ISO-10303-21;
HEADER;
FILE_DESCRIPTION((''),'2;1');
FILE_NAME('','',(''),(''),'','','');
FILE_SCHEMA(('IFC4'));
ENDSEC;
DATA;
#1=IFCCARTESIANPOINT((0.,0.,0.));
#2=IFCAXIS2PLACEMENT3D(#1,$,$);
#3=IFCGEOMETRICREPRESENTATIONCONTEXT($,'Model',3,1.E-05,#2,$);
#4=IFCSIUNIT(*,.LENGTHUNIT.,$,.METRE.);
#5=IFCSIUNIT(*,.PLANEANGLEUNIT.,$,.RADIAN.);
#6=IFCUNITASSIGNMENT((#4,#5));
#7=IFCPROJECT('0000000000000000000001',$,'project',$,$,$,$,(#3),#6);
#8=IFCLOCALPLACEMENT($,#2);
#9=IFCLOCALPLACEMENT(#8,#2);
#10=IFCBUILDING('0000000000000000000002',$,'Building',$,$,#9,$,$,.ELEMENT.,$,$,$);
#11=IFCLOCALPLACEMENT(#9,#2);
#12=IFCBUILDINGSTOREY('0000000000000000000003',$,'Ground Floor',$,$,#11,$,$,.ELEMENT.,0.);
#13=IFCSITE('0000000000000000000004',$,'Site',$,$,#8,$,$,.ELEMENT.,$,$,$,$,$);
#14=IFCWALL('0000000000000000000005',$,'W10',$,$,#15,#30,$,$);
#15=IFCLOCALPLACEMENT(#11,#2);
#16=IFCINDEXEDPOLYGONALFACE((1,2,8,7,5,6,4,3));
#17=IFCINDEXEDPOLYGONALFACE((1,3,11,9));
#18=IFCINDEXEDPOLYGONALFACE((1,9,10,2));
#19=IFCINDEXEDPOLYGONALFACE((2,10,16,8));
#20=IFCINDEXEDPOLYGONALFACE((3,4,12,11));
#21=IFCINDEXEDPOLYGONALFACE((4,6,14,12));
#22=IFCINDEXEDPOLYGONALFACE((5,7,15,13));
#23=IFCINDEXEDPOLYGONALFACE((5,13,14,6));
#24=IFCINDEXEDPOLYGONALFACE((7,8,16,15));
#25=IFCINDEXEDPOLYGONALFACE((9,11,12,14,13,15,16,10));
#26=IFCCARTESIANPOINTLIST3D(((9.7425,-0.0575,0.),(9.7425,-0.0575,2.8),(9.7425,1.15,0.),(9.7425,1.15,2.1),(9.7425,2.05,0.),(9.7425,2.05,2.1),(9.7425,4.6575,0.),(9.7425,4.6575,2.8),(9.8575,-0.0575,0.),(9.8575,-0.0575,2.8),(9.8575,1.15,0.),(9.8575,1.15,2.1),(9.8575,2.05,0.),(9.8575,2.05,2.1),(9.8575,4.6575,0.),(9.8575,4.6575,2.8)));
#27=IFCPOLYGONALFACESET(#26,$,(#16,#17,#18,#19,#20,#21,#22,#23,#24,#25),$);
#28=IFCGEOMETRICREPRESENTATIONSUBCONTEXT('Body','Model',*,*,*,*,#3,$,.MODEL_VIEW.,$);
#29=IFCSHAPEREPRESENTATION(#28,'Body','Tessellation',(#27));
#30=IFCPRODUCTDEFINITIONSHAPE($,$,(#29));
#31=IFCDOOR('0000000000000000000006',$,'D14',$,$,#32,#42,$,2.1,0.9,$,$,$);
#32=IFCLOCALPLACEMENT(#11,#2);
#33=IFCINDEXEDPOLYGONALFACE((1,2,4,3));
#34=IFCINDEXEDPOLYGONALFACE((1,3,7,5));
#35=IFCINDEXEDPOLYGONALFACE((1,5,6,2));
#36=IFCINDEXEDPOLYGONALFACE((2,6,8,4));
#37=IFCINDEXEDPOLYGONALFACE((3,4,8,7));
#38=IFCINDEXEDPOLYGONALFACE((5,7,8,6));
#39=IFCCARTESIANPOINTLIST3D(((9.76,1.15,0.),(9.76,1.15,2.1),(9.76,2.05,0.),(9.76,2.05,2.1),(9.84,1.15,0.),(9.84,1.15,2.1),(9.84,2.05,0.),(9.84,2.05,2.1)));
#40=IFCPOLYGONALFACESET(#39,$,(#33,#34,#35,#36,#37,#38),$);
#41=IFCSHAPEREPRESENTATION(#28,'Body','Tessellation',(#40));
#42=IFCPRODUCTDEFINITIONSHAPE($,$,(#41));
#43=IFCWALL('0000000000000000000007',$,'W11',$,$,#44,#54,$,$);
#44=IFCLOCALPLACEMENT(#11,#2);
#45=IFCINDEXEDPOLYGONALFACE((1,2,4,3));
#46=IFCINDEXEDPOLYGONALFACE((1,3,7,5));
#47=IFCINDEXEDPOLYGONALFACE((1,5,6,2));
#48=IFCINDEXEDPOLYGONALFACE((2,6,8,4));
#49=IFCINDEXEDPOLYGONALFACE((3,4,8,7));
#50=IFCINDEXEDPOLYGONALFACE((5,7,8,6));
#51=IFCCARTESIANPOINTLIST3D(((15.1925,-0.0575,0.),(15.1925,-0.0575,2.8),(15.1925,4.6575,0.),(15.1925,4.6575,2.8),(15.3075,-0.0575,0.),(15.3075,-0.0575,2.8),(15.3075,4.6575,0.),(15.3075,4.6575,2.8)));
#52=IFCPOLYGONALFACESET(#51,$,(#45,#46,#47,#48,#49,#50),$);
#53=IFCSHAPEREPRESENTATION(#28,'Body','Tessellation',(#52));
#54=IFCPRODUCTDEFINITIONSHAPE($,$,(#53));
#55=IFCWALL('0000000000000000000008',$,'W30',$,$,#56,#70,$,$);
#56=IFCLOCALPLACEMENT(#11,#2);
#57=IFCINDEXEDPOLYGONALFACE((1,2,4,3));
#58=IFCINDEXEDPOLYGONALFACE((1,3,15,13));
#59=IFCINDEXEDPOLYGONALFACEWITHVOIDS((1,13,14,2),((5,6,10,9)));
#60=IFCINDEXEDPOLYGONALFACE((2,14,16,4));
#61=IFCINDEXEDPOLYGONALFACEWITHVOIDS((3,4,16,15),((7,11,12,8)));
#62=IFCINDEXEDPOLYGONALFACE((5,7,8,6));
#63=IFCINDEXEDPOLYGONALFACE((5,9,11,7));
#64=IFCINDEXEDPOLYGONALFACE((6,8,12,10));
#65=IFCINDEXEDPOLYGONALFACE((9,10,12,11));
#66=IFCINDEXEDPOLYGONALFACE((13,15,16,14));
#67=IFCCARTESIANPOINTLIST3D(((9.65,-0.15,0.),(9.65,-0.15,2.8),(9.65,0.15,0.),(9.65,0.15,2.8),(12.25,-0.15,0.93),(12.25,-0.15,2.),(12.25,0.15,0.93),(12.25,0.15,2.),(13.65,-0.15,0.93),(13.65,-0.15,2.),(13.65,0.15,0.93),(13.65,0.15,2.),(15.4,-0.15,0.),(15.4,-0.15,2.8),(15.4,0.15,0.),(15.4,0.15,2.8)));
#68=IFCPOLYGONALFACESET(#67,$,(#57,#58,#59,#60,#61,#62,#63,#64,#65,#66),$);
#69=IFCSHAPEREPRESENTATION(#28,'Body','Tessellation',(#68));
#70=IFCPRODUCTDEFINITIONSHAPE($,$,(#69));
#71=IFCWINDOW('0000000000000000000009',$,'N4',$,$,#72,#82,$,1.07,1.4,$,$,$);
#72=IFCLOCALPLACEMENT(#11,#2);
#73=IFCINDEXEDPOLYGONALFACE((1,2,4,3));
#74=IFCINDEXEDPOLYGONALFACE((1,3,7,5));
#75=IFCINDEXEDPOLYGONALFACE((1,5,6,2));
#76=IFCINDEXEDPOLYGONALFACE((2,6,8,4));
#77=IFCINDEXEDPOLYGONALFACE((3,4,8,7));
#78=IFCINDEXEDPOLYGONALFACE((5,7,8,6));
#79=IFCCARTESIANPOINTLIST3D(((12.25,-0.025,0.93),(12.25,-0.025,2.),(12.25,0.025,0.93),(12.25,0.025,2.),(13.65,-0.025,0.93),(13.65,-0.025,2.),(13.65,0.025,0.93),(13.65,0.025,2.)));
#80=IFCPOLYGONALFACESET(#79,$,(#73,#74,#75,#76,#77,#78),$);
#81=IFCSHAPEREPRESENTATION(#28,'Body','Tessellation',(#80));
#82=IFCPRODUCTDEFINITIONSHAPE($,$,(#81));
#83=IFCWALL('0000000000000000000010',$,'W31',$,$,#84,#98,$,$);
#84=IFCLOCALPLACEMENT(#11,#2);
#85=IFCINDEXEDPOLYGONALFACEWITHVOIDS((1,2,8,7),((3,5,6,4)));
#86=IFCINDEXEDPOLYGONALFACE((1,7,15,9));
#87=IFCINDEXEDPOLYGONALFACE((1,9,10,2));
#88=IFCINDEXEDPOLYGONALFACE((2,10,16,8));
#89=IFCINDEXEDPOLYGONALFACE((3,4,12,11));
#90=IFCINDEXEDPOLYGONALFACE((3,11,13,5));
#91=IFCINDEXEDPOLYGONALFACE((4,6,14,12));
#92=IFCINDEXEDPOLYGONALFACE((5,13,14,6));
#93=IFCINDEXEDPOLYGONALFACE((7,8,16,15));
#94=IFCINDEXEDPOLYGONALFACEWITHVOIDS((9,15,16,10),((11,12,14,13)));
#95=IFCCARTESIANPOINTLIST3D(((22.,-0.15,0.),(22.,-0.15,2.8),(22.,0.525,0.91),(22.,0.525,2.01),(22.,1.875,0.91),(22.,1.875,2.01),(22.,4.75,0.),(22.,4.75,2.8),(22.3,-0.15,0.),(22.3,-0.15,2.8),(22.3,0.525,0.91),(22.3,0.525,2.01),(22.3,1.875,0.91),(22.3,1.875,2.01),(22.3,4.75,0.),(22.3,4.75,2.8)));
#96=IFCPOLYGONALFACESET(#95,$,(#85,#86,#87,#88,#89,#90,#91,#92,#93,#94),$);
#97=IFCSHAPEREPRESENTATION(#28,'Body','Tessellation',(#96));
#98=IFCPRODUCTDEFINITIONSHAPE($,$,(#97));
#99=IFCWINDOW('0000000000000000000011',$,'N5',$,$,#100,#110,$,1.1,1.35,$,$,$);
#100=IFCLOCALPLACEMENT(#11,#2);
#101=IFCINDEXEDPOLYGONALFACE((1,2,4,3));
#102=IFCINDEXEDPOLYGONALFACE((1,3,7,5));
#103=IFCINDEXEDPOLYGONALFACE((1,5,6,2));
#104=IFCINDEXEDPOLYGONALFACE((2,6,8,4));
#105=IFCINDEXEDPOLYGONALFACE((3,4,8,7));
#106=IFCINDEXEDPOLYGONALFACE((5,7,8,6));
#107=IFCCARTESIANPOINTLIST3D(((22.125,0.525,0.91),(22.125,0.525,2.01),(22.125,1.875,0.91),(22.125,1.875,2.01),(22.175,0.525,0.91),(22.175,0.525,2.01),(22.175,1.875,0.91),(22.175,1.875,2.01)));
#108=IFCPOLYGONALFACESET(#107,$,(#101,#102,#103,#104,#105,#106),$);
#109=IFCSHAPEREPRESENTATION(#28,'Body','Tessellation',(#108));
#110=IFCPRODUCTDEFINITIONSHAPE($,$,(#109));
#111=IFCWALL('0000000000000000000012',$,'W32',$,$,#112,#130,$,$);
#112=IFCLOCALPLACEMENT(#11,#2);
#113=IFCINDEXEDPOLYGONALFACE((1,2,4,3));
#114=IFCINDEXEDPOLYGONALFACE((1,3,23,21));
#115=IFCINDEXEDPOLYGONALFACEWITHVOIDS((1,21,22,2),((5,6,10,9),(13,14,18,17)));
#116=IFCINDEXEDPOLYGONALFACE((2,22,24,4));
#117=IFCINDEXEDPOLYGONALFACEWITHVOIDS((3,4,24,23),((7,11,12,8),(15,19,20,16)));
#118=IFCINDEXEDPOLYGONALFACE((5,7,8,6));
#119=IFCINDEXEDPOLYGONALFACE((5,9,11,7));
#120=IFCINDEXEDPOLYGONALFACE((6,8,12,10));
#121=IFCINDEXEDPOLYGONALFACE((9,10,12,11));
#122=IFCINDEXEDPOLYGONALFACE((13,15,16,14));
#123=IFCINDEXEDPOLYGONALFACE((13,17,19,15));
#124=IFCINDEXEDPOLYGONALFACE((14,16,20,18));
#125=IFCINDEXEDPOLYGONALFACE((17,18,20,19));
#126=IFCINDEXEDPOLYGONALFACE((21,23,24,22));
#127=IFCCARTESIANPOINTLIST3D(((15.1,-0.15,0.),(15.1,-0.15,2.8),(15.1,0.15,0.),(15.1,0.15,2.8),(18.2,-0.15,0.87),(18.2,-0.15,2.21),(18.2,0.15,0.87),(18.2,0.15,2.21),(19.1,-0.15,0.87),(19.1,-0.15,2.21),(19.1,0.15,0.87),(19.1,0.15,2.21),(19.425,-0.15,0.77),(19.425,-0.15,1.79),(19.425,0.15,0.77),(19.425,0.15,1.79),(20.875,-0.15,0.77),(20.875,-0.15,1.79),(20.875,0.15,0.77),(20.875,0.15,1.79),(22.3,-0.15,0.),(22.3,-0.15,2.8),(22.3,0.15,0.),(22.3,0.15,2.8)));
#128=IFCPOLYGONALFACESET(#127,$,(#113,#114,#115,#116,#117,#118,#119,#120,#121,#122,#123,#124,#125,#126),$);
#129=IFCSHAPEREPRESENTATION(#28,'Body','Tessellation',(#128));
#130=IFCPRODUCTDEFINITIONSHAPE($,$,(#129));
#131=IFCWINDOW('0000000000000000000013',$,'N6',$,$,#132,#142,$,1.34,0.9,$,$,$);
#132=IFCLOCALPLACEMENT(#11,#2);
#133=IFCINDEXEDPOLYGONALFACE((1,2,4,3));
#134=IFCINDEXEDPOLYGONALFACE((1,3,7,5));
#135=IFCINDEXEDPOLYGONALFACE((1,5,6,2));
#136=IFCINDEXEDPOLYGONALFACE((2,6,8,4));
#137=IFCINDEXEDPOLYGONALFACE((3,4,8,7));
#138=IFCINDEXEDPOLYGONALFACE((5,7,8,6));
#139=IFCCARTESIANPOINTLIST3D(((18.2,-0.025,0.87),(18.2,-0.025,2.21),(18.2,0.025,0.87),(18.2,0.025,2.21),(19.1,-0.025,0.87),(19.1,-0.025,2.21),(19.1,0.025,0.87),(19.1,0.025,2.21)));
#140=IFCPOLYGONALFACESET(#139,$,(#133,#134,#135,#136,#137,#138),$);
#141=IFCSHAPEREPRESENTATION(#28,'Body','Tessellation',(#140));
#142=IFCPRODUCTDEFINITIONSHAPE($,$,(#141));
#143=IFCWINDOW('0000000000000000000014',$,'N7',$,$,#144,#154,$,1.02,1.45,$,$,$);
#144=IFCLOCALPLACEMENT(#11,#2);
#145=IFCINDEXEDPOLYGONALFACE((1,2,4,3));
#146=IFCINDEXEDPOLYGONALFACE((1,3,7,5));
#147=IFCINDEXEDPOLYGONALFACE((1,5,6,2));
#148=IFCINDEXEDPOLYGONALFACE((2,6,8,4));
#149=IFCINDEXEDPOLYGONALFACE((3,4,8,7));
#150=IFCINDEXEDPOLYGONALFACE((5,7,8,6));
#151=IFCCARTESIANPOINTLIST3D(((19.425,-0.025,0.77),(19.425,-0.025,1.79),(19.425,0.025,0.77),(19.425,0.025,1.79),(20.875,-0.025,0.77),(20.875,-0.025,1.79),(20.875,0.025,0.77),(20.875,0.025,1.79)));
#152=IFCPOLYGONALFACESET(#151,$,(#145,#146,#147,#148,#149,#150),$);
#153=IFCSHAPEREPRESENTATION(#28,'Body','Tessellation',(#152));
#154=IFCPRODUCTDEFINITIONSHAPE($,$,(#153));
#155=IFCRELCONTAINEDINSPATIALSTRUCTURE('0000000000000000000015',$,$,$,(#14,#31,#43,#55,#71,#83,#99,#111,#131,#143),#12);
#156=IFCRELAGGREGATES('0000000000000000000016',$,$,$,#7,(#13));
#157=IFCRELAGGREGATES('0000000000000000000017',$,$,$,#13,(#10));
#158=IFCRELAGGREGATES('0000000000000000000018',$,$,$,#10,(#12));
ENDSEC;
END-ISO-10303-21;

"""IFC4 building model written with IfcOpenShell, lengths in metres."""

from ifc_helpers import new_model, si_unit, frame, frame_2d, origin, origin_2d, place, context, subcontext, project, spatial, rectangle, extrude, element, fill, save


model = new_model("IFC4")

# Units and contexts
model_context = context("Model", 3, precision=1e-05, world=origin())
body_context = subcontext(model_context, "Body", "Model", "MODEL_VIEW")
ifc_project = project(units=[si_unit("LENGTHUNIT", "METRE"), si_unit("PLANEANGLEUNIT", "RADIAN")], contexts=[model_context])

# Site, building, storey
site_placement = place(None, origin())
site = spatial("IfcSite", under=ifc_project, at=site_placement, Name="Site", CompositionType="ELEMENT")
building_placement = place(site_placement, origin())
building = spatial("IfcBuilding", under=site, at=building_placement, Name="Building", CompositionType="ELEMENT")
storey_placement = place(building_placement, origin())
storey = spatial("IfcBuildingStorey", under=building, at=storey_placement, Name="Ground Floor", CompositionType="ELEMENT", Elevation=0.0)

# Wall, opening, door
wall_1_placement = place(storey_placement, frame((9.8, 0.0, 0.0), x_axis=(0.0, 1.0, 0.0)))
wall_1 = element("IfcWall", 1, at=wall_1_placement, inside=storey, Name="W10", context=body_context, shape_type="SweptSolid", body=[
    extrude(rectangle(XDim=4.715, YDim=0.115, at=frame_2d((2.3, 0.0))), origin(), (0.0, 0.0, 1.0), 2.8),
])
opening_1_placement = place(wall_1_placement, frame((1.6, 0.0, 0.0)))
opening_1 = element("IfcOpeningElement", 2, at=opening_1_placement, cuts=wall_1, context=body_context, shape_type="SweptSolid", body=[
    extrude(rectangle(XDim=0.9, YDim=0.215, at=origin_2d()), origin(), (0.0, 0.0, 1.0), 2.1),
])
door_1_placement = place(opening_1_placement, origin())
door_1 = element("IfcDoor", 3, at=door_1_placement, inside=storey, Name="D14", OverallHeight=2.1, OverallWidth=0.9, context=body_context, shape_type="SweptSolid", body=[
    extrude(rectangle(XDim=0.9, YDim=0.08, at=origin_2d()), origin(), (0.0, 0.0, 1.0), 2.1),
])
fill(opening_1, door_1)

# Wall
wall_2_placement = place(storey_placement, frame((15.25, 0.0, 0.0), x_axis=(0.0, 1.0, 0.0)))
element("IfcWall", 4, at=wall_2_placement, inside=storey, Name="W11", context=body_context, shape_type="SweptSolid", body=[
    extrude(rectangle(XDim=4.715, YDim=0.115, at=frame_2d((2.3, 0.0))), origin(), (0.0, 0.0, 1.0), 2.8),
])

# Walls, openings, windows
wall_3_placement = place(storey_placement, frame((9.8, 0.0, 0.0), x_axis=(1.0, 0.0, 0.0)))
wall_3 = element("IfcWall", 5, at=wall_3_placement, inside=storey, Name="W30", context=body_context, shape_type="SweptSolid", body=[
    extrude(rectangle(XDim=5.75, YDim=0.3, at=frame_2d((2.725, 0.0))), origin(), (0.0, 0.0, 1.0), 2.8),
])
opening_2_placement = place(wall_3_placement, frame((3.15, 0.0, 0.93)))
opening_2 = element("IfcOpeningElement", 6, at=opening_2_placement, cuts=wall_3, context=body_context, shape_type="SweptSolid", body=[
    extrude(rectangle(XDim=1.4, YDim=0.4, at=origin_2d()), origin(), (0.0, 0.0, 1.0), 1.07),
])
window_1_placement = place(opening_2_placement, origin())
window_1 = element("IfcWindow", 7, at=window_1_placement, inside=storey, Name="N4", OverallHeight=1.07, OverallWidth=1.4, context=body_context, shape_type="SweptSolid", body=[
    extrude(rectangle(XDim=1.4, YDim=0.05, at=origin_2d()), origin(), (0.0, 0.0, 1.0), 1.07),
])
fill(opening_2, window_1)
wall_4_placement = place(storey_placement, frame((22.15, 0.0, 0.0), x_axis=(0.0, 1.0, 0.0)))
wall_4 = element("IfcWall", 8, at=wall_4_placement, inside=storey, Name="W31", context=body_context, shape_type="SweptSolid", body=[
    extrude(rectangle(XDim=4.9, YDim=0.3, at=frame_2d((2.3, 0.0))), origin(), (0.0, 0.0, 1.0), 2.8),
])
opening_3_placement = place(wall_4_placement, frame((1.2, 0.0, 0.91)))
opening_3 = element("IfcOpeningElement", 9, at=opening_3_placement, cuts=wall_4, context=body_context, shape_type="SweptSolid", body=[
    extrude(rectangle(XDim=1.35, YDim=0.4, at=origin_2d()), origin(), (0.0, 0.0, 1.0), 1.1),
])
window_2_placement = place(opening_3_placement, origin())
window_2 = element("IfcWindow", 10, at=window_2_placement, inside=storey, Name="N5", OverallHeight=1.1, OverallWidth=1.35, context=body_context, shape_type="SweptSolid", body=[
    extrude(rectangle(XDim=1.35, YDim=0.05, at=origin_2d()), origin(), (0.0, 0.0, 1.0), 1.1),
])
fill(opening_3, window_2)

# Wall, openings, windows
wall_5_placement = place(storey_placement, frame((15.25, 0.0, 0.0), x_axis=(1.0, 0.0, 0.0)))
wall_5 = element("IfcWall", 11, at=wall_5_placement, inside=storey, Name="W32", context=body_context, shape_type="SweptSolid", body=[
    extrude(rectangle(XDim=7.2, YDim=0.3, at=frame_2d((3.45, 0.0))), origin(), (0.0, 0.0, 1.0), 2.8),
])
opening_4_placement = place(wall_5_placement, frame((3.4, 0.0, 0.87)))
opening_4 = element("IfcOpeningElement", 12, at=opening_4_placement, cuts=wall_5, context=body_context, shape_type="SweptSolid", body=[
    extrude(rectangle(XDim=0.9, YDim=0.4, at=origin_2d()), origin(), (0.0, 0.0, 1.0), 1.34),
])
opening_5_placement = place(wall_5_placement, frame((4.9, 0.0, 0.77)))
opening_5 = element("IfcOpeningElement", 13, at=opening_5_placement, cuts=wall_5, context=body_context, shape_type="SweptSolid", body=[
    extrude(rectangle(XDim=1.45, YDim=0.4, at=origin_2d()), origin(), (0.0, 0.0, 1.0), 1.02),
])
window_3_placement = place(opening_4_placement, origin())
window_3 = element("IfcWindow", 14, at=window_3_placement, inside=storey, Name="N6", OverallHeight=1.34, OverallWidth=0.9, context=body_context, shape_type="SweptSolid", body=[
    extrude(rectangle(XDim=0.9, YDim=0.05, at=origin_2d()), origin(), (0.0, 0.0, 1.0), 1.34),
])
fill(opening_4, window_3)
window_4_placement = place(opening_5_placement, origin())
window_4 = element("IfcWindow", 15, at=window_4_placement, inside=storey, Name="N7", OverallHeight=1.02, OverallWidth=1.45, context=body_context, shape_type="SweptSolid", body=[
    extrude(rectangle(XDim=1.45, YDim=0.05, at=origin_2d()), origin(), (0.0, 0.0, 1.0), 1.02),
])
fill(opening_5, window_4)

save(model, "model.ifc")
